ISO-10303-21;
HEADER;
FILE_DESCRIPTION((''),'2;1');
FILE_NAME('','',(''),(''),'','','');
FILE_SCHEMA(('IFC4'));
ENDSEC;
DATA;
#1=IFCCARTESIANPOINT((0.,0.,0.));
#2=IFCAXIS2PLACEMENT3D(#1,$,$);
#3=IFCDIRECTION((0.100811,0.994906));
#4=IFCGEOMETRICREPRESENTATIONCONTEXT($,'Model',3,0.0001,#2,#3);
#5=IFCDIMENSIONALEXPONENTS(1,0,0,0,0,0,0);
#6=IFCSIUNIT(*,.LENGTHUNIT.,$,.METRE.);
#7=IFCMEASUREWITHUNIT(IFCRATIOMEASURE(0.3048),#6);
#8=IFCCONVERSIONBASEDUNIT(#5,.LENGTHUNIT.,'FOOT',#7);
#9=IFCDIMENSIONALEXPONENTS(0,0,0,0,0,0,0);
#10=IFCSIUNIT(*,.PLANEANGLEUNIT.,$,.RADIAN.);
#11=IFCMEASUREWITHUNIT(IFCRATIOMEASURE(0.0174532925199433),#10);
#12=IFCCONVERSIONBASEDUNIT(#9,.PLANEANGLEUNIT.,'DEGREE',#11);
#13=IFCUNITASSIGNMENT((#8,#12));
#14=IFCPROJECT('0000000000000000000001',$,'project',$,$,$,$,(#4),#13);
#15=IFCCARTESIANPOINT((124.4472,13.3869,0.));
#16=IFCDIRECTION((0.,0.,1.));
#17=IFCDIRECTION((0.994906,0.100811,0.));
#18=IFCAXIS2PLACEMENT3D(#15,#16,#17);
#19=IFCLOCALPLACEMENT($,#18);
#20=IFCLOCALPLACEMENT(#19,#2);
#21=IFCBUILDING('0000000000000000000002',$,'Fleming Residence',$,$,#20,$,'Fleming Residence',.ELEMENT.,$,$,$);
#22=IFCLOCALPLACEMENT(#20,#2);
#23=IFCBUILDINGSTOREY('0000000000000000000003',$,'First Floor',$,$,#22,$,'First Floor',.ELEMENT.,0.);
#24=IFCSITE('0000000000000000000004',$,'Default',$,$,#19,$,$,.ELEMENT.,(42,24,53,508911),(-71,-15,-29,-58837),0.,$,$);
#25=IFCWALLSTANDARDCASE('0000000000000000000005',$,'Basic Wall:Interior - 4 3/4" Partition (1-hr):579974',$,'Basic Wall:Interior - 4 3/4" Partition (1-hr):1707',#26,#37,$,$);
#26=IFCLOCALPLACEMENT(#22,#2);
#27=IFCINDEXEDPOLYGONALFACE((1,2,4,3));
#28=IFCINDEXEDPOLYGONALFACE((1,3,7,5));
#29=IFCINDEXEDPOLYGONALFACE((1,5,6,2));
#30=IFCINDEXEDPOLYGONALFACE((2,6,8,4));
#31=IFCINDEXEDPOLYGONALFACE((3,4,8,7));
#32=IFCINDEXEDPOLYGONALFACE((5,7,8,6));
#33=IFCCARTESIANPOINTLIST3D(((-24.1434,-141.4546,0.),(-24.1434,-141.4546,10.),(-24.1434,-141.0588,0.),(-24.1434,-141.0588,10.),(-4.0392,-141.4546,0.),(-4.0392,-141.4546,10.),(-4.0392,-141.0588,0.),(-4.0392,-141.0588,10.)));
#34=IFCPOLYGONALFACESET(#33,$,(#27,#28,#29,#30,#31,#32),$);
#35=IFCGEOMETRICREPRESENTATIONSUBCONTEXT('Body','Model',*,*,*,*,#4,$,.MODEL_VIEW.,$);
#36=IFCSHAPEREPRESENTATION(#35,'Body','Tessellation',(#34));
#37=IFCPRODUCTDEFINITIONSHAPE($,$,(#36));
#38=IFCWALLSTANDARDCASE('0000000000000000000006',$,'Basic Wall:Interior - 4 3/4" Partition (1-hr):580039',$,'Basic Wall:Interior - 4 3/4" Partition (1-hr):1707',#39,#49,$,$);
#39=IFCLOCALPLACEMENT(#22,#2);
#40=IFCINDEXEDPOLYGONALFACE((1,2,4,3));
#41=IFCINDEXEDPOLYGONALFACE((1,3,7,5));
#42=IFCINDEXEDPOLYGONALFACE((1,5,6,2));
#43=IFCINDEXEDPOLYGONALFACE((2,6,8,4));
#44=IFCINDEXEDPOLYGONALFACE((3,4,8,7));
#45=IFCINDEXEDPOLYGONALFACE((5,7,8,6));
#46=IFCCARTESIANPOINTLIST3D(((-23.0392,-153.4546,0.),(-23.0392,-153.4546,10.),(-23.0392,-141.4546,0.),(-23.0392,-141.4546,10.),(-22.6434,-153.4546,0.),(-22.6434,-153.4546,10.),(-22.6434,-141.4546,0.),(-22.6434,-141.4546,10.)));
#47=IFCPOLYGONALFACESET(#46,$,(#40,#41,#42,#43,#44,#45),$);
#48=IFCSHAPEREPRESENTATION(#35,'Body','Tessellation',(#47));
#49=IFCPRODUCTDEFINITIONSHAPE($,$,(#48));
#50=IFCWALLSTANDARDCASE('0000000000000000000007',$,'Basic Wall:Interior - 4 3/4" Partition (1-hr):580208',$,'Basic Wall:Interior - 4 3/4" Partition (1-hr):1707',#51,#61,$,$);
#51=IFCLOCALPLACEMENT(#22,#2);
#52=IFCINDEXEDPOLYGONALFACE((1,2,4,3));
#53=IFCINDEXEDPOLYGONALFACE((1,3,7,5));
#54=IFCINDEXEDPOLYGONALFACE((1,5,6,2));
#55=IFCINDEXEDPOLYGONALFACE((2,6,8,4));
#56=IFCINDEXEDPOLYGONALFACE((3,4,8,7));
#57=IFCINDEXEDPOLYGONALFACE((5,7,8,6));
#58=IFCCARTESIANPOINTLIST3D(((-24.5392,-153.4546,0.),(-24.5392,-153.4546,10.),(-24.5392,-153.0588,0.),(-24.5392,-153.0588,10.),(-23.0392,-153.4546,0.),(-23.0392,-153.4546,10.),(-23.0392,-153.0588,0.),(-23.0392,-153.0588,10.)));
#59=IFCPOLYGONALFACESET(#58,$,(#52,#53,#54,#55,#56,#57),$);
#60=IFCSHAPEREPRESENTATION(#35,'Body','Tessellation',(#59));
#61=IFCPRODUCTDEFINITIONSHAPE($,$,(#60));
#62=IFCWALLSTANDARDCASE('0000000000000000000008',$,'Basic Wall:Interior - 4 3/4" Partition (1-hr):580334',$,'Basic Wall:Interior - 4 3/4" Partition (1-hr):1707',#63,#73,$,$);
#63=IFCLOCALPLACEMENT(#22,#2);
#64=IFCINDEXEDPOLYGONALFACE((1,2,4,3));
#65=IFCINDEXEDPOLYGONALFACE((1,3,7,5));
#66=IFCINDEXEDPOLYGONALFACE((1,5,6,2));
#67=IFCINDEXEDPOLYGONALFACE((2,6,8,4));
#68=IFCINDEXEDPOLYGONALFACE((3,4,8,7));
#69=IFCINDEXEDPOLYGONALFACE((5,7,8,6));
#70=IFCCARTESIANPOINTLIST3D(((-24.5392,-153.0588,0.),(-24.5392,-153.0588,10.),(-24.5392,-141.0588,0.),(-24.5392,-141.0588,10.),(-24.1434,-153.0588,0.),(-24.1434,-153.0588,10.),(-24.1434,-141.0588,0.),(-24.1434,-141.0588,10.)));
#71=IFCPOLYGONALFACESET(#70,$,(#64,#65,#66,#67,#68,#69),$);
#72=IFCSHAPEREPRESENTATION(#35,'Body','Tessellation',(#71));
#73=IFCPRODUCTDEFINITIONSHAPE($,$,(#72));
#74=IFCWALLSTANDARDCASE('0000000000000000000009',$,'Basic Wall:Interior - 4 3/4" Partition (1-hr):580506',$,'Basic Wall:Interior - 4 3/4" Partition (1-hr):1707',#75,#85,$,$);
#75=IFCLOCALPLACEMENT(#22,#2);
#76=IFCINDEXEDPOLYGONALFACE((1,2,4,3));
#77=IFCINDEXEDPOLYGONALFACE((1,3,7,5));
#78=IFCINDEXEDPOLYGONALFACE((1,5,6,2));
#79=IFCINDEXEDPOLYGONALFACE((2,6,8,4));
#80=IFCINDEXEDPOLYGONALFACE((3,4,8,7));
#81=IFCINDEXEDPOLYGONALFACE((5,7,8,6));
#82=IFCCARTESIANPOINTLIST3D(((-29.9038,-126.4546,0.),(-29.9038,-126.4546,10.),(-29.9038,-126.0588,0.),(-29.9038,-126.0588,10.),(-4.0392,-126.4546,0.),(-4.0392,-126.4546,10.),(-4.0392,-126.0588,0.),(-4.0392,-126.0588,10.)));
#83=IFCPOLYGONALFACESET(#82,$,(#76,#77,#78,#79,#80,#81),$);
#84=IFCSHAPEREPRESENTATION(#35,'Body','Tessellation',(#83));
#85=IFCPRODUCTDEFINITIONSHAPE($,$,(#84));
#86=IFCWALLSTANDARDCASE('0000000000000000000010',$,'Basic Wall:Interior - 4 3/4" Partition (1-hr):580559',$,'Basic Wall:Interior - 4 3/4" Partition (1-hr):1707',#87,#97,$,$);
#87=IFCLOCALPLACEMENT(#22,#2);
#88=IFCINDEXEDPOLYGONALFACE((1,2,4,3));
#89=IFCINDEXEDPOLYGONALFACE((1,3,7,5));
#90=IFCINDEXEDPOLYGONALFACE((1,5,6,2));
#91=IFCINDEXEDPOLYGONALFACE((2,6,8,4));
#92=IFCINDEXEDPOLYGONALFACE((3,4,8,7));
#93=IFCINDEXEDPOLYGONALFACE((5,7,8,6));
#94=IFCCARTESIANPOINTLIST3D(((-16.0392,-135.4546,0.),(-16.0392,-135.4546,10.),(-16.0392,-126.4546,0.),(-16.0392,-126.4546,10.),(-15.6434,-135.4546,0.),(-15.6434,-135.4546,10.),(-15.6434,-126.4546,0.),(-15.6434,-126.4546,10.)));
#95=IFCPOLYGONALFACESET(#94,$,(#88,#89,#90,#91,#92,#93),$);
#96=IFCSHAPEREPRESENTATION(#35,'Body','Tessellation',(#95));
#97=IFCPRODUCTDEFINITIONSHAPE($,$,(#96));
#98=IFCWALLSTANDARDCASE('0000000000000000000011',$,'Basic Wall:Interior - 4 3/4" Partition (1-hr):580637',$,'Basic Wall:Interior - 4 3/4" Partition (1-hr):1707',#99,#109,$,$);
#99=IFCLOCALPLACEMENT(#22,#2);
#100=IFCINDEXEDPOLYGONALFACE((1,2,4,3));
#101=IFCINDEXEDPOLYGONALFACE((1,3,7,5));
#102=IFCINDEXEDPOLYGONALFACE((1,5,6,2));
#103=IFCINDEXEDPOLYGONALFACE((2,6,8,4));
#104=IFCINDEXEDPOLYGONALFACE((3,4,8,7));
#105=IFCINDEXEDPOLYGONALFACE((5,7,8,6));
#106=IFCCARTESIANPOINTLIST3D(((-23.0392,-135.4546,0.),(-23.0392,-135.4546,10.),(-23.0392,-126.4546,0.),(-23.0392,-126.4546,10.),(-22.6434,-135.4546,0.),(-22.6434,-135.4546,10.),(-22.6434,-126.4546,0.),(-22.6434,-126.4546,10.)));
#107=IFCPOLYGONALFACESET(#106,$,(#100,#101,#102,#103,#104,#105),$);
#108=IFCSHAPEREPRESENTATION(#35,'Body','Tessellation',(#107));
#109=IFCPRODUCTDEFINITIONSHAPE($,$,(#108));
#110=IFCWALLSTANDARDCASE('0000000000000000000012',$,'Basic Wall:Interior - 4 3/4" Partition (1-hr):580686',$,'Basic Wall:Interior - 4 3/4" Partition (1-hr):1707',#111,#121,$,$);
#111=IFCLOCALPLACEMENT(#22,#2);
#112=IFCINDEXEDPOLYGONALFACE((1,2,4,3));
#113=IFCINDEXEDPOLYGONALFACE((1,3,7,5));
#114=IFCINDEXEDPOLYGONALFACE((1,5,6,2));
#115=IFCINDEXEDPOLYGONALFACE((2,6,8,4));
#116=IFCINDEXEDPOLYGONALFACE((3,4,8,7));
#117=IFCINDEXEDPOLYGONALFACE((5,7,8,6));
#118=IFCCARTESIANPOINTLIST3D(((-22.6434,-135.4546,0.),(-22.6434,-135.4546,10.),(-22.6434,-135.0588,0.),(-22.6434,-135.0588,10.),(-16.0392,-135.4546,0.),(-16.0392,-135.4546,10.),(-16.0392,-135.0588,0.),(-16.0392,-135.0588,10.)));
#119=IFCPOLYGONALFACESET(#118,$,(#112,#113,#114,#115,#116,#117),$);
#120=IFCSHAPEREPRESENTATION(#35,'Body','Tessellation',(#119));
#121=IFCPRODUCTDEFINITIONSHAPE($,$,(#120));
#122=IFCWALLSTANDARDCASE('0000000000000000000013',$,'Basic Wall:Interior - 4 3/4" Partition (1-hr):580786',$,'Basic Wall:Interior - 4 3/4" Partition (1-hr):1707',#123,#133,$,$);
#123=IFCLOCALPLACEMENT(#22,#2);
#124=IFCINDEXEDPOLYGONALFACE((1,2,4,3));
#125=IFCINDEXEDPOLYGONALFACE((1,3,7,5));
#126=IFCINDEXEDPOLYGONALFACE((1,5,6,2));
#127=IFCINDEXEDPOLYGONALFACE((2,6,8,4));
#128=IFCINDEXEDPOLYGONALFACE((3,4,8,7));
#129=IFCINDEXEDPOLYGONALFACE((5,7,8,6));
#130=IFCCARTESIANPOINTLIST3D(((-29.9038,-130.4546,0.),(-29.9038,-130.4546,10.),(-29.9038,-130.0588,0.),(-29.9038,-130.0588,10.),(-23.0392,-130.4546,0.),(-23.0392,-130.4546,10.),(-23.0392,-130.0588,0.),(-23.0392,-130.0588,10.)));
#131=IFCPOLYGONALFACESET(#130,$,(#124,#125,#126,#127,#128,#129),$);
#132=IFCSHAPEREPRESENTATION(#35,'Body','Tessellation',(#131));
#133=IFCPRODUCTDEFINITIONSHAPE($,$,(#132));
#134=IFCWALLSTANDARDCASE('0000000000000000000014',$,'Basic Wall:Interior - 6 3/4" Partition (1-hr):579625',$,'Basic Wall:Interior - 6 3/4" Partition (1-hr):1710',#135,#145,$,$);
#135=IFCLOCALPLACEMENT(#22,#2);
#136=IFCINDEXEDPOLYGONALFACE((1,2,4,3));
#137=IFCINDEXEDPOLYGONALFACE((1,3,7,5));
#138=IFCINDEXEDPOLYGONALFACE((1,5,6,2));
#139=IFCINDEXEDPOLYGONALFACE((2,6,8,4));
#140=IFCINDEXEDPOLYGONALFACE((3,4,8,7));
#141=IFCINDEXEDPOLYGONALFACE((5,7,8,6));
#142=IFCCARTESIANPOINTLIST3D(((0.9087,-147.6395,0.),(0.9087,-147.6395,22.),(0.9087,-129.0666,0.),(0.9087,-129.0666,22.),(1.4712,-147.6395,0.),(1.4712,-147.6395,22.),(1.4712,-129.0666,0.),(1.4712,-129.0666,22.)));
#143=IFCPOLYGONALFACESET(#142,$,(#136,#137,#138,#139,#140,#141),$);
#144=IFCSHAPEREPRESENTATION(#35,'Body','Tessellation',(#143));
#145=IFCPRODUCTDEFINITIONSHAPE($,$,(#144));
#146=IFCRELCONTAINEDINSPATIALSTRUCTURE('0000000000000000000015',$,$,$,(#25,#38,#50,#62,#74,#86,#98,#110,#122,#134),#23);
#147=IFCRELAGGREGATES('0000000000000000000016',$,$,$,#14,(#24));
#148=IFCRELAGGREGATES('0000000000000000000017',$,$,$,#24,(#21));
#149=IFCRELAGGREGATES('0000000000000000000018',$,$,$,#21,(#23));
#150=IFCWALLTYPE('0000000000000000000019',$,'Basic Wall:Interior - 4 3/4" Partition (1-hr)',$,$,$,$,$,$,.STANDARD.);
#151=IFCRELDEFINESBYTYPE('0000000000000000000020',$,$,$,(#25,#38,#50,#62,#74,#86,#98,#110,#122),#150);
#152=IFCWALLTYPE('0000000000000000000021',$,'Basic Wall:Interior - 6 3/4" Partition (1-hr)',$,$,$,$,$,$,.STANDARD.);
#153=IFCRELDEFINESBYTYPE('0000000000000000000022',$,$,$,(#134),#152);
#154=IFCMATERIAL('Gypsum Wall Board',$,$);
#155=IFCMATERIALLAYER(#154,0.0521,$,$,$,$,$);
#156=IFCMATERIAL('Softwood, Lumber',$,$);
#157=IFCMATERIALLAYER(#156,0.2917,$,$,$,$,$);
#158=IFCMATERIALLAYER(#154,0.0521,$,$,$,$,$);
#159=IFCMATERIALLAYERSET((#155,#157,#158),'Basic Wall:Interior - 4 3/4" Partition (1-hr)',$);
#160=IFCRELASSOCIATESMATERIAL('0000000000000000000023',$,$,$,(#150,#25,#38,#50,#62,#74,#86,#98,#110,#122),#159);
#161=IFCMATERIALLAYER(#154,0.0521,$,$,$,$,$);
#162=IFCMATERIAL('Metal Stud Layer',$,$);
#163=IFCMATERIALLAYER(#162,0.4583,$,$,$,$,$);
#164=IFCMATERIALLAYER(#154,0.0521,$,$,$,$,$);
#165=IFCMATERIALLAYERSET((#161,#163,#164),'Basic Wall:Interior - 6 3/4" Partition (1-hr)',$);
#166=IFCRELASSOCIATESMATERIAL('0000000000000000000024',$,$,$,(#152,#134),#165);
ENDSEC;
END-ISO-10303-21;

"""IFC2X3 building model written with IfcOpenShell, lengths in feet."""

from ifc_helpers import new_model, entity, si_unit, converted_unit, direction, frame, frame_2d, origin, place, context, subcontext, project, spatial, rectangle, extrude, material, layer, layer_set, layer_usage, type_object, element, save


model = new_model("IFC2X3")

# Units and contexts
model_context = context("Model", 3, precision=0.0001, world=origin(), true_north=direction((0.100811, 0.994906)))
body_context = subcontext(model_context, "Body", "Model", "MODEL_VIEW")
ifc_project = project(units=[converted_unit("LENGTHUNIT", "FOOT", entity("IfcRatioMeasure", 0.3048), si_unit("LENGTHUNIT", "METRE"), dimensions=[1, 0, 0, 0, 0, 0, 0]), converted_unit("PLANEANGLEUNIT", "DEGREE", entity("IfcRatioMeasure", 0.0174532925199433), si_unit("PLANEANGLEUNIT", "RADIAN"), dimensions=[0, 0, 0, 0, 0, 0, 0])], contexts=[model_context])

# Site, building, storey
site_placement = place(None, frame((124.4472, 13.3869, 0.0), z_axis=(0.0, 0.0, 1.0), x_axis=(0.994906, 0.100811, 0.0)))
site = spatial("IfcSite", under=ifc_project, at=site_placement, Name="Default", CompositionType="ELEMENT", RefLatitude=(42, 24, 53, 508911), RefLongitude=(-71, -15, -29, -58837), RefElevation=0.0)
building_placement = place(site_placement, origin())
building = spatial("IfcBuilding", under=site, at=building_placement, Name="Fleming Residence", LongName="Fleming Residence", CompositionType="ELEMENT")
storey_placement = place(building_placement, origin())
storey = spatial("IfcBuildingStorey", under=building, at=storey_placement, Name="First Floor", LongName="First Floor", CompositionType="ELEMENT", Elevation=0.0)

# Walls
ifc_material_1 = material(Name="Softwood, Lumber")
ifc_material_2 = material(Name="Gypsum Wall Board")
ifc_layer_1 = layer(ifc_material_2, 0.0521)
ifc_layer_2 = layer(ifc_material_1, 0.2917)
ifc_layer_3 = layer(ifc_material_2, 0.0521)
ifc_layer_set_1 = layer_set([ifc_layer_1, ifc_layer_2, ifc_layer_3], Name="Basic Wall:Interior - 4 3/4\" Partition (1-hr)")
wall_type_1 = type_object("IfcWallType", Name="Basic Wall:Interior - 4 3/4\" Partition (1-hr)", PredefinedType="STANDARD", material=ifc_layer_set_1)
ifc_layer_usage_1 = layer_usage(ifc_layer_set_1, "AXIS2", "NEGATIVE", 0.1979)
wall_1_placement = place(storey_placement, frame((-4.0392, -141.2567, 0.0), z_axis=(0.0, 0.0, 1.0), x_axis=(-1.0, 0.0, 0.0)))
element("IfcWallStandardCase", 1, at=wall_1_placement, inside=storey, type_object=wall_type_1, material=ifc_layer_usage_1, Name="Basic Wall:Interior - 4 3/4\" Partition (1-hr):579974", ObjectType="Basic Wall:Interior - 4 3/4\" Partition (1-hr):1707", context=body_context, shape_type="SweptSolid", body=[
    extrude(rectangle(XDim=20.1042, YDim=0.3958, at=frame_2d((10.0521, 0.0), x_axis=(-1.0, 0.0))), origin(), (0.0, 0.0, 1.0), 10.0),
])
ifc_layer_usage_2 = layer_usage(ifc_layer_set_1, "AXIS2", "NEGATIVE", 0.1979)
wall_2_placement = place(storey_placement, frame((-22.8413, -141.4546, 0.0), z_axis=(0.0, 0.0, 1.0), x_axis=(0.0, -1.0, 0.0)))
element("IfcWallStandardCase", 2, at=wall_2_placement, inside=storey, type_object=wall_type_1, material=ifc_layer_usage_2, Name="Basic Wall:Interior - 4 3/4\" Partition (1-hr):580039", ObjectType="Basic Wall:Interior - 4 3/4\" Partition (1-hr):1707", context=body_context, shape_type="SweptSolid", body=[
    extrude(rectangle(XDim=12.0, YDim=0.3958, at=frame_2d((6.0, 0.0), x_axis=(-1.0, 0.0))), origin(), (0.0, 0.0, 1.0), 10.0),
])
ifc_layer_usage_3 = layer_usage(ifc_layer_set_1, "AXIS2", "NEGATIVE", 0.1979)
wall_3_placement = place(storey_placement, frame((-23.0392, -153.2567, 0.0), z_axis=(0.0, 0.0, 1.0), x_axis=(-1.0, 0.0, 0.0)))
element("IfcWallStandardCase", 3, at=wall_3_placement, inside=storey, type_object=wall_type_1, material=ifc_layer_usage_3, Name="Basic Wall:Interior - 4 3/4\" Partition (1-hr):580208", ObjectType="Basic Wall:Interior - 4 3/4\" Partition (1-hr):1707", context=body_context, shape_type="SweptSolid", body=[
    extrude(rectangle(XDim=1.5, YDim=0.3958, at=frame_2d((0.75, 0.0), x_axis=(-1.0, 0.0))), origin(), (0.0, 0.0, 1.0), 10.0),
])
ifc_layer_usage_4 = layer_usage(ifc_layer_set_1, "AXIS2", "NEGATIVE", 0.1979)
wall_4_placement = place(storey_placement, frame((-24.3413, -153.0588, 0.0), z_axis=(0.0, 0.0, 1.0), x_axis=(0.0, 1.0, 0.0)))
element("IfcWallStandardCase", 4, at=wall_4_placement, inside=storey, type_object=wall_type_1, material=ifc_layer_usage_4, Name="Basic Wall:Interior - 4 3/4\" Partition (1-hr):580334", ObjectType="Basic Wall:Interior - 4 3/4\" Partition (1-hr):1707", context=body_context, shape_type="SweptSolid", body=[
    extrude(rectangle(XDim=12.0, YDim=0.3958, at=frame_2d((6.0, 0.0), x_axis=(-1.0, 0.0))), origin(), (0.0, 0.0, 1.0), 10.0),
])
ifc_layer_usage_5 = layer_usage(ifc_layer_set_1, "AXIS2", "NEGATIVE", 0.1979)
wall_5_placement = place(storey_placement, frame((-4.0392, -126.2567, 0.0), z_axis=(0.0, 0.0, 1.0), x_axis=(-1.0, 0.0, 0.0)))
element("IfcWallStandardCase", 5, at=wall_5_placement, inside=storey, type_object=wall_type_1, material=ifc_layer_usage_5, Name="Basic Wall:Interior - 4 3/4\" Partition (1-hr):580506", ObjectType="Basic Wall:Interior - 4 3/4\" Partition (1-hr):1707", context=body_context, shape_type="SweptSolid", body=[
    extrude(rectangle(XDim=25.8646, YDim=0.3958, at=frame_2d((12.9323, 0.0), x_axis=(-1.0, 0.0))), origin(), (0.0, 0.0, 1.0), 10.0),
])
ifc_layer_usage_6 = layer_usage(ifc_layer_set_1, "AXIS2", "NEGATIVE", 0.1979)
wall_6_placement = place(storey_placement, frame((-15.8413, -135.4546, 0.0), z_axis=(0.0, 0.0, 1.0), x_axis=(0.0, 1.0, 0.0)))
element("IfcWallStandardCase", 6, at=wall_6_placement, inside=storey, type_object=wall_type_1, material=ifc_layer_usage_6, Name="Basic Wall:Interior - 4 3/4\" Partition (1-hr):580559", ObjectType="Basic Wall:Interior - 4 3/4\" Partition (1-hr):1707", context=body_context, shape_type="SweptSolid", body=[
    extrude(rectangle(XDim=9.0, YDim=0.3958, at=frame_2d((4.5, 0.0), x_axis=(-1.0, 0.0))), origin(), (0.0, 0.0, 1.0), 10.0),
])
ifc_layer_usage_7 = layer_usage(ifc_layer_set_1, "AXIS2", "NEGATIVE", 0.1979)
wall_7_placement = place(storey_placement, frame((-22.8413, -126.4546, 0.0), z_axis=(0.0, 0.0, 1.0), x_axis=(0.0, -1.0, 0.0)))
element("IfcWallStandardCase", 7, at=wall_7_placement, inside=storey, type_object=wall_type_1, material=ifc_layer_usage_7, Name="Basic Wall:Interior - 4 3/4\" Partition (1-hr):580637", ObjectType="Basic Wall:Interior - 4 3/4\" Partition (1-hr):1707", context=body_context, shape_type="SweptSolid", body=[
    extrude(rectangle(XDim=9.0, YDim=0.3958, at=frame_2d((4.5, 0.0), x_axis=(-1.0, 0.0))), origin(), (0.0, 0.0, 1.0), 10.0),
])
ifc_layer_usage_8 = layer_usage(ifc_layer_set_1, "AXIS2", "NEGATIVE", 0.1979)
wall_8_placement = place(storey_placement, frame((-22.6434, -135.2567, 0.0)))
element("IfcWallStandardCase", 8, at=wall_8_placement, inside=storey, type_object=wall_type_1, material=ifc_layer_usage_8, Name="Basic Wall:Interior - 4 3/4\" Partition (1-hr):580686", ObjectType="Basic Wall:Interior - 4 3/4\" Partition (1-hr):1707", context=body_context, shape_type="SweptSolid", body=[
    extrude(rectangle(XDim=6.6042, YDim=0.3958, at=frame_2d((3.3021, 0.0), x_axis=(-1.0, 0.0))), origin(), (0.0, 0.0, 1.0), 10.0),
])
ifc_layer_usage_9 = layer_usage(ifc_layer_set_1, "AXIS2", "NEGATIVE", 0.1979)
wall_9_placement = place(storey_placement, frame((-29.9038, -130.2567, 0.0)))
element("IfcWallStandardCase", 9, at=wall_9_placement, inside=storey, type_object=wall_type_1, material=ifc_layer_usage_9, Name="Basic Wall:Interior - 4 3/4\" Partition (1-hr):580786", ObjectType="Basic Wall:Interior - 4 3/4\" Partition (1-hr):1707", context=body_context, shape_type="SweptSolid", body=[
    extrude(rectangle(XDim=6.8646, YDim=0.3958, at=frame_2d((3.4323, 0.0), x_axis=(-1.0, 0.0))), origin(), (0.0, 0.0, 1.0), 10.0),
])
ifc_layer_4 = layer(ifc_material_2, 0.0521)
ifc_material_3 = material(Name="Metal Stud Layer")
ifc_layer_5 = layer(ifc_material_3, 0.4583)
ifc_layer_6 = layer(ifc_material_2, 0.0521)
ifc_layer_set_2 = layer_set([ifc_layer_4, ifc_layer_5, ifc_layer_6], Name="Basic Wall:Interior - 6 3/4\" Partition (1-hr)")
ifc_layer_usage_10 = layer_usage(ifc_layer_set_2, "AXIS2", "NEGATIVE", 0.2812)
wall_type_2 = type_object("IfcWallType", Name="Basic Wall:Interior - 6 3/4\" Partition (1-hr)", PredefinedType="STANDARD", material=ifc_layer_set_2)
wall_10_placement = place(storey_placement, frame((1.19, -147.6395, 0.0), z_axis=(0.0, 0.0, 1.0), x_axis=(0.0, 1.0, 0.0)))
element("IfcWallStandardCase", 10, at=wall_10_placement, inside=storey, type_object=wall_type_2, material=ifc_layer_usage_10, Name="Basic Wall:Interior - 6 3/4\" Partition (1-hr):579625", ObjectType="Basic Wall:Interior - 6 3/4\" Partition (1-hr):1710", context=body_context, shape_type="SweptSolid", body=[
    extrude(rectangle(XDim=18.5729, YDim=0.5625, at=frame_2d((9.2865, 0.0), x_axis=(-1.0, 0.0))), origin(), (0.0, 0.0, 1.0), 22.0),
])

save(model, "model.ifc")
